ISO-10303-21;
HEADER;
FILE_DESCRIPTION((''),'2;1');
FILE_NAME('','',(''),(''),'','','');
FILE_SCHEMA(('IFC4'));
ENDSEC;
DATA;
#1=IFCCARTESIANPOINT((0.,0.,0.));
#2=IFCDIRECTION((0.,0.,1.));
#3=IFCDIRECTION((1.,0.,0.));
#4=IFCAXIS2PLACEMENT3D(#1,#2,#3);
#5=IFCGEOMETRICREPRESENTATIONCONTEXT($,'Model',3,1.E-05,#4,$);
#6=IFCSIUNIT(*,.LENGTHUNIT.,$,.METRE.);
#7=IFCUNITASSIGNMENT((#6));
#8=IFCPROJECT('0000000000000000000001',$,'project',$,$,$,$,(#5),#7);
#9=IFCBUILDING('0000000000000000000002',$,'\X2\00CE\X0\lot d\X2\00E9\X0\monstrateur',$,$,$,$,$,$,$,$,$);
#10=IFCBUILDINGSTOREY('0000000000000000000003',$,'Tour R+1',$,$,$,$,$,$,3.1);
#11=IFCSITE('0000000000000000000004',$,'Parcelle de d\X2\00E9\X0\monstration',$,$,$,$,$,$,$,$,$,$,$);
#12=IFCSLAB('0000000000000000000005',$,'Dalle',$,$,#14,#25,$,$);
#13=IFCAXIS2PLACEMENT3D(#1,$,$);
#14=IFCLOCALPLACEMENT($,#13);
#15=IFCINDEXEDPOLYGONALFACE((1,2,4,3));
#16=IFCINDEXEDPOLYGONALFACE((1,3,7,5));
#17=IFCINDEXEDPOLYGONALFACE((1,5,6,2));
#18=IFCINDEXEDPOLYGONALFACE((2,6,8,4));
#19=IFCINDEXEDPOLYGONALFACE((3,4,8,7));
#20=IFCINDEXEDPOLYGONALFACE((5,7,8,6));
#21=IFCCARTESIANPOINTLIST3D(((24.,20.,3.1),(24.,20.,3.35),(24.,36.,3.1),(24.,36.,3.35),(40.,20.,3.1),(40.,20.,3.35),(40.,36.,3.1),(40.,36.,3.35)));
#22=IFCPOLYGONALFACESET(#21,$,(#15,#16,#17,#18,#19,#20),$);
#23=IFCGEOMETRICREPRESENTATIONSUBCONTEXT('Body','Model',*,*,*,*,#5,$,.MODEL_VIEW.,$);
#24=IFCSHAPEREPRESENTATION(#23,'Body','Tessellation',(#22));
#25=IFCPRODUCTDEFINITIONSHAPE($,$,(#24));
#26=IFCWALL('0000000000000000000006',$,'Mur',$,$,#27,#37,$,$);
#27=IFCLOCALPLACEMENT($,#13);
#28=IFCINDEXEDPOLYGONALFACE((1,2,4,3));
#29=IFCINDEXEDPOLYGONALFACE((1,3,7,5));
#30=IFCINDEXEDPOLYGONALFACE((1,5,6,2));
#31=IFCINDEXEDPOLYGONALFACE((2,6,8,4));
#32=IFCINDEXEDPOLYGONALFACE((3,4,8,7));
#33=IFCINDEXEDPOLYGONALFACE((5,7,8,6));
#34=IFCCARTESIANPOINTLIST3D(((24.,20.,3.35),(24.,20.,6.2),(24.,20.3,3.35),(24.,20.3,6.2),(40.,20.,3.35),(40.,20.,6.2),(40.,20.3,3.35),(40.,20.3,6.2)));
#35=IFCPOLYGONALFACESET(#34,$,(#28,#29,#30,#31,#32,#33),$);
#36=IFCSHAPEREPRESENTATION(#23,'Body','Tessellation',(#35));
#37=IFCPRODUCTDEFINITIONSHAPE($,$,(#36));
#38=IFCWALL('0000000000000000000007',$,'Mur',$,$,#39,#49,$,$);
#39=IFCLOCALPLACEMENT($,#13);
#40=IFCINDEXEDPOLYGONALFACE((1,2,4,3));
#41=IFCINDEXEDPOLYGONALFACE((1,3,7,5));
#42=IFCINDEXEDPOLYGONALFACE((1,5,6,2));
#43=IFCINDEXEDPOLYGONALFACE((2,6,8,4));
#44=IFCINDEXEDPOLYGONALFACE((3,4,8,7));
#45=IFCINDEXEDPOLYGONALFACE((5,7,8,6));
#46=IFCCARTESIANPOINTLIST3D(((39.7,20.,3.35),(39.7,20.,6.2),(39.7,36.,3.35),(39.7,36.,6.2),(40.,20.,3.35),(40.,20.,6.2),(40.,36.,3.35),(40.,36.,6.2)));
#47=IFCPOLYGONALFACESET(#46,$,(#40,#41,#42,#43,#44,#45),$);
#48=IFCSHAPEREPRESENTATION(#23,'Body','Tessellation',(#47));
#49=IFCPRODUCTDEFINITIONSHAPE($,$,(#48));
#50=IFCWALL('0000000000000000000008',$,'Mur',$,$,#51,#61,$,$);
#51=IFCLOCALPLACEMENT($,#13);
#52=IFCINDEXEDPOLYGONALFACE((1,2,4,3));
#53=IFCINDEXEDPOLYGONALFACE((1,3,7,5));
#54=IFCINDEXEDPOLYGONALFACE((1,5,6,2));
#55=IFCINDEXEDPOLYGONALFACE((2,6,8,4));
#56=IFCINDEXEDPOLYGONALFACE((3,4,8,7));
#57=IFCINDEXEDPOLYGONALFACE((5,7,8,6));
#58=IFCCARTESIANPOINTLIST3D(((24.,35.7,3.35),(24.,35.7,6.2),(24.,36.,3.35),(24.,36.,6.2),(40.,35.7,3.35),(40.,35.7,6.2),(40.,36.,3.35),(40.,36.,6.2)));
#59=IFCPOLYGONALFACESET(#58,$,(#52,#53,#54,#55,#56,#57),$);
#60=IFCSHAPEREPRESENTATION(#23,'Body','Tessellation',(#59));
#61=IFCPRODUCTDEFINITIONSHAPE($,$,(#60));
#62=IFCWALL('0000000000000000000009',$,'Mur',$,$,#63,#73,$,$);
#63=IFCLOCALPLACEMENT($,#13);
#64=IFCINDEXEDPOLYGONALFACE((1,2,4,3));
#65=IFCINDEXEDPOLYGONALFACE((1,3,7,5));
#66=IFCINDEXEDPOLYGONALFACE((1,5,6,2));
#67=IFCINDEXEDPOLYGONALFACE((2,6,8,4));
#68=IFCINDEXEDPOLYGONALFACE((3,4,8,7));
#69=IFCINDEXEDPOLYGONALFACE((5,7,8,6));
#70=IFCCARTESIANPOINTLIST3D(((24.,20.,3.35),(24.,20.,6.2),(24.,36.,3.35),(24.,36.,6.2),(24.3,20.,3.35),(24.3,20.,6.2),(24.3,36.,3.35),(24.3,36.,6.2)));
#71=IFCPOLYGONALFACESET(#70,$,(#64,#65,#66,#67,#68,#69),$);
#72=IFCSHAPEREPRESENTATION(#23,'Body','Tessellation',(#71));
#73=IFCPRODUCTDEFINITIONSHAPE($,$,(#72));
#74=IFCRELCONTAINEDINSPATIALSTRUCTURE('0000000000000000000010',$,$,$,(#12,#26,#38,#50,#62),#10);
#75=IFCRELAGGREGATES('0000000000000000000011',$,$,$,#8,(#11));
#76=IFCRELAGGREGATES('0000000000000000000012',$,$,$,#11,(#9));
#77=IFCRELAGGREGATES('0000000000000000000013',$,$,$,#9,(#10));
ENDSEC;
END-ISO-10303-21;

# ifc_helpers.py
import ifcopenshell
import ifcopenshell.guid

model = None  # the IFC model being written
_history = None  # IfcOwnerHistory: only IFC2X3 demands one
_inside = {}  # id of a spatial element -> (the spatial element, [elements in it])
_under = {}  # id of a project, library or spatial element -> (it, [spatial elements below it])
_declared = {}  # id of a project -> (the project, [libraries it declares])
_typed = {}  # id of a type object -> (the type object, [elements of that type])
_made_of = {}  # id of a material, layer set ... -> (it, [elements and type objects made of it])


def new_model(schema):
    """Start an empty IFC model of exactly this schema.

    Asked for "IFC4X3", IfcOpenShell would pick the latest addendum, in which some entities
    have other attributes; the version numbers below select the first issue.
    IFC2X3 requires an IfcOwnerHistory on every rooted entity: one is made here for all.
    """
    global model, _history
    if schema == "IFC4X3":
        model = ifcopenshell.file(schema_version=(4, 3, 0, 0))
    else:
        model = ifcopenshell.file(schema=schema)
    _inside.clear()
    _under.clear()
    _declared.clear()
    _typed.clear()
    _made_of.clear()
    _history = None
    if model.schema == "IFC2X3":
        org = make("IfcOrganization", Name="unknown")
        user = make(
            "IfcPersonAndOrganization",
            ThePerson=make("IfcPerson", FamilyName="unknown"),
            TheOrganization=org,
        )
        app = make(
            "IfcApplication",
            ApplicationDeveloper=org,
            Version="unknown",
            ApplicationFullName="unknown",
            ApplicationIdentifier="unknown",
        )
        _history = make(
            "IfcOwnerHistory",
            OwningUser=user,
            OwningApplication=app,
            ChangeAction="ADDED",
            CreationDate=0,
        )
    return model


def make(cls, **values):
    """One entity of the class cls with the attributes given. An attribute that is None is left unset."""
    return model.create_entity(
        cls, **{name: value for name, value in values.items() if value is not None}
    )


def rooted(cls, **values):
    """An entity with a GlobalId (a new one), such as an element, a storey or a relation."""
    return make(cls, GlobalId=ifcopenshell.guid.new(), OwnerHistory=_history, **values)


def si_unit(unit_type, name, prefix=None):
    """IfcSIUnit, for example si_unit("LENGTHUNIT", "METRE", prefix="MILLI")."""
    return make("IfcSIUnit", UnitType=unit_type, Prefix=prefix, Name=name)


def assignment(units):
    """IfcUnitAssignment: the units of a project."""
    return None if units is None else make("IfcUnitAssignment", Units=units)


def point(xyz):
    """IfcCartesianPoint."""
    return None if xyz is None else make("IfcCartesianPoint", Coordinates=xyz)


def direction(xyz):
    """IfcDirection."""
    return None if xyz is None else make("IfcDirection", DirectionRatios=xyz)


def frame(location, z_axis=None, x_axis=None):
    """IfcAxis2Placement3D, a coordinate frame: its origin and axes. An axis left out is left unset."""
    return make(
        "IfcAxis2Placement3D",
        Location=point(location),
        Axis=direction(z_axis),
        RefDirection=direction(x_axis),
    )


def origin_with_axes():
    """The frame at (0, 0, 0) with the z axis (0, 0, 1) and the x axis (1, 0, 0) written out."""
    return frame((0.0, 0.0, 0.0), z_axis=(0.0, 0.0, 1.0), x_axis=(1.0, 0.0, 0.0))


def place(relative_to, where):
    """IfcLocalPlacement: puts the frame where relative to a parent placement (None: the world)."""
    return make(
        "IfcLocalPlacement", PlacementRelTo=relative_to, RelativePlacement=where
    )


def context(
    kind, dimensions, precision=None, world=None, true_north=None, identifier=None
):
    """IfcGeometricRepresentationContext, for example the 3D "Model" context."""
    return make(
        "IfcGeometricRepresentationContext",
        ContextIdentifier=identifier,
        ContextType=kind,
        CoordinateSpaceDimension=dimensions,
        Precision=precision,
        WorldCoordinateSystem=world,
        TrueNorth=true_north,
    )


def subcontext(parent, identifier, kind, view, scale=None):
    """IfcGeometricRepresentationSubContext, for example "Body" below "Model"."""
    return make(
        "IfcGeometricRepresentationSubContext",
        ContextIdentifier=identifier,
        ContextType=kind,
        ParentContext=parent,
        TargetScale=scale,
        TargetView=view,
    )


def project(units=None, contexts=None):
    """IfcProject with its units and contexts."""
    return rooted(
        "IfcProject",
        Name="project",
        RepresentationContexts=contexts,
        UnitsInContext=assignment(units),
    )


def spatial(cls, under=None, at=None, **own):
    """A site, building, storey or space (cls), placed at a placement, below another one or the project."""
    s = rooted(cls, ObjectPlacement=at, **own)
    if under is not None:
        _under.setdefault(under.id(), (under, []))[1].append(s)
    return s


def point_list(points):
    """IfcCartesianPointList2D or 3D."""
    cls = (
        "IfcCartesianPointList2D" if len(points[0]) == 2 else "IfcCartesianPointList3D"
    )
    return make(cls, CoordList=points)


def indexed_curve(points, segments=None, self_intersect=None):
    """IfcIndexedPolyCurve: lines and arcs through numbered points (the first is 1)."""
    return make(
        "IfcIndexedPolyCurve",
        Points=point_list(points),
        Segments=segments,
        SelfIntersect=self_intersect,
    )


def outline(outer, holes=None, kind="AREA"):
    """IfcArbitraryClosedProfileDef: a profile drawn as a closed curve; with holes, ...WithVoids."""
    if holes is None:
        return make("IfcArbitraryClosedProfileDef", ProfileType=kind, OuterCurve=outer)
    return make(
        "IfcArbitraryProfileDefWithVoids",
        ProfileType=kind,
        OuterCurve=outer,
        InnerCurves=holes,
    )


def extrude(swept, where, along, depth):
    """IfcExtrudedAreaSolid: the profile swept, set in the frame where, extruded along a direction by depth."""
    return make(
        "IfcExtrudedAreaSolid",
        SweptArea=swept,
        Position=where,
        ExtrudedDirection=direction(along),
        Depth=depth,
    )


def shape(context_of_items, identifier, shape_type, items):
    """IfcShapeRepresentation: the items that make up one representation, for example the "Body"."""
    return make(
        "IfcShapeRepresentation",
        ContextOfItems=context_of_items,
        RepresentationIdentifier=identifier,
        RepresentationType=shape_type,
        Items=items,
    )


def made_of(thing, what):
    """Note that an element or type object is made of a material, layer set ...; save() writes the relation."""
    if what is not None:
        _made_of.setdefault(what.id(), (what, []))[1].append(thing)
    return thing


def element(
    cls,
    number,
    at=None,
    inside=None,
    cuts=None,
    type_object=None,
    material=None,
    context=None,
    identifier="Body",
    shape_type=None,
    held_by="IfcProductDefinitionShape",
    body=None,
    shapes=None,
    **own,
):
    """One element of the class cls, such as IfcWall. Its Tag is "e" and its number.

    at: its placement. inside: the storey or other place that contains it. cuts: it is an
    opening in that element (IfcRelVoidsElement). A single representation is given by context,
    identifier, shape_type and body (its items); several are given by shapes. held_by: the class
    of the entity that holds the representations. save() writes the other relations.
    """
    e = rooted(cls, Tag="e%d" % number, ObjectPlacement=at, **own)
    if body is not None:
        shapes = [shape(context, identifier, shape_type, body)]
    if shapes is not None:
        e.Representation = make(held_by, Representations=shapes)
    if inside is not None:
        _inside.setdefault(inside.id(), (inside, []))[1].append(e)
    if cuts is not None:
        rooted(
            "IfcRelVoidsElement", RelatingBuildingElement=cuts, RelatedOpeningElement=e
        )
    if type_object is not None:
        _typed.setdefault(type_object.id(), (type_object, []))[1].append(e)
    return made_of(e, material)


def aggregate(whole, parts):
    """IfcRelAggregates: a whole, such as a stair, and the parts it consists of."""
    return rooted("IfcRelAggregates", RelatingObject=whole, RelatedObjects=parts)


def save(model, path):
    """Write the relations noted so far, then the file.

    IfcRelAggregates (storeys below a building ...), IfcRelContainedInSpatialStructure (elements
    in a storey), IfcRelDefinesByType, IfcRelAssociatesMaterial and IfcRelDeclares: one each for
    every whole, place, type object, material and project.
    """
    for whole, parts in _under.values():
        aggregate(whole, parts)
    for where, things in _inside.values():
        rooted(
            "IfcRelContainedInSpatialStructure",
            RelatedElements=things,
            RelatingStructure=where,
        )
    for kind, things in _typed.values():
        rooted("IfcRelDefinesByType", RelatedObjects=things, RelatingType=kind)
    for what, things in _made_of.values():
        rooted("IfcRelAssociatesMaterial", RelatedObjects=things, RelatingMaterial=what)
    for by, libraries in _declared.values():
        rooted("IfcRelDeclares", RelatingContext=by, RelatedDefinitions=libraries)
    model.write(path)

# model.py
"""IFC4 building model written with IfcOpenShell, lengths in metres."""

from ifc_helpers import new_model, si_unit, frame, origin_with_axes, place, context, subcontext, project, spatial, indexed_curve, outline, extrude, element, save


model = new_model("IFC4")

# Units and contexts
model_context = context("Model", 3, precision=1e-05, world=origin_with_axes())
body_context = subcontext(model_context, "Body", "Model", "MODEL_VIEW")
ifc_project = project(units=[si_unit("LENGTHUNIT", "METRE")], contexts=[model_context])

# Site, building, storey
site = spatial("IfcSite", under=ifc_project, Name="Parcelle de démonstration")
building = spatial("IfcBuilding", under=site, Name="Îlot démonstrateur")
storey = spatial("IfcBuildingStorey", under=building, Name="Tour R+1", Elevation=3.1)

# Slab
slab_placement = place(None, frame((0.0, 0.0, 3.1), z_axis=(0.0, 0.0, 1.0), x_axis=(1.0, 0.0, 0.0)))
element("IfcSlab", 1, at=slab_placement, inside=storey, Name="Dalle", context=body_context, shape_type="SweptSolid", body=[
    extrude(outline(indexed_curve([(24.0, 20.0), (40.0, 20.0), (40.0, 36.0), (24.0, 36.0)])), None, (0.0, 0.0, 1.0), 0.25),
])

# Walls
for number, where, z_axis, x_axis, name in (
    (2, (24.0, 20.0, 3.35), (0.0, 0.0, 1.0), (1.0, 0.0, 0.0), "Mur"),
    (3, (40.0, 20.0, 3.35), (0.0, 0.0, 1.0), (0.0, 1.0, 0.0), "Mur"),
    (4, (40.0, 36.0, 3.35), (0.0, 0.0, 1.0), (-1.0, 0.0, 0.0), "Mur"),
    (5, (24.0, 36.0, 3.35), (0.0, 0.0, 1.0), (0.0, -1.0, 0.0), "Mur"),
):
    element("IfcWall", number, at=place(None, frame(where, z_axis=z_axis, x_axis=x_axis)), inside=storey, Name=name, context=body_context, shape_type="SweptSolid", body=[
        extrude(outline(indexed_curve([(0.0, 0.0), (0.0, 0.3), (16.0, 0.3), (16.0, 0.0), (0.0, 0.0)], self_intersect=False)), origin_with_axes(), (0.0, 0.0, 1.0), 2.85),
    ])

save(model, "model.ifc")
